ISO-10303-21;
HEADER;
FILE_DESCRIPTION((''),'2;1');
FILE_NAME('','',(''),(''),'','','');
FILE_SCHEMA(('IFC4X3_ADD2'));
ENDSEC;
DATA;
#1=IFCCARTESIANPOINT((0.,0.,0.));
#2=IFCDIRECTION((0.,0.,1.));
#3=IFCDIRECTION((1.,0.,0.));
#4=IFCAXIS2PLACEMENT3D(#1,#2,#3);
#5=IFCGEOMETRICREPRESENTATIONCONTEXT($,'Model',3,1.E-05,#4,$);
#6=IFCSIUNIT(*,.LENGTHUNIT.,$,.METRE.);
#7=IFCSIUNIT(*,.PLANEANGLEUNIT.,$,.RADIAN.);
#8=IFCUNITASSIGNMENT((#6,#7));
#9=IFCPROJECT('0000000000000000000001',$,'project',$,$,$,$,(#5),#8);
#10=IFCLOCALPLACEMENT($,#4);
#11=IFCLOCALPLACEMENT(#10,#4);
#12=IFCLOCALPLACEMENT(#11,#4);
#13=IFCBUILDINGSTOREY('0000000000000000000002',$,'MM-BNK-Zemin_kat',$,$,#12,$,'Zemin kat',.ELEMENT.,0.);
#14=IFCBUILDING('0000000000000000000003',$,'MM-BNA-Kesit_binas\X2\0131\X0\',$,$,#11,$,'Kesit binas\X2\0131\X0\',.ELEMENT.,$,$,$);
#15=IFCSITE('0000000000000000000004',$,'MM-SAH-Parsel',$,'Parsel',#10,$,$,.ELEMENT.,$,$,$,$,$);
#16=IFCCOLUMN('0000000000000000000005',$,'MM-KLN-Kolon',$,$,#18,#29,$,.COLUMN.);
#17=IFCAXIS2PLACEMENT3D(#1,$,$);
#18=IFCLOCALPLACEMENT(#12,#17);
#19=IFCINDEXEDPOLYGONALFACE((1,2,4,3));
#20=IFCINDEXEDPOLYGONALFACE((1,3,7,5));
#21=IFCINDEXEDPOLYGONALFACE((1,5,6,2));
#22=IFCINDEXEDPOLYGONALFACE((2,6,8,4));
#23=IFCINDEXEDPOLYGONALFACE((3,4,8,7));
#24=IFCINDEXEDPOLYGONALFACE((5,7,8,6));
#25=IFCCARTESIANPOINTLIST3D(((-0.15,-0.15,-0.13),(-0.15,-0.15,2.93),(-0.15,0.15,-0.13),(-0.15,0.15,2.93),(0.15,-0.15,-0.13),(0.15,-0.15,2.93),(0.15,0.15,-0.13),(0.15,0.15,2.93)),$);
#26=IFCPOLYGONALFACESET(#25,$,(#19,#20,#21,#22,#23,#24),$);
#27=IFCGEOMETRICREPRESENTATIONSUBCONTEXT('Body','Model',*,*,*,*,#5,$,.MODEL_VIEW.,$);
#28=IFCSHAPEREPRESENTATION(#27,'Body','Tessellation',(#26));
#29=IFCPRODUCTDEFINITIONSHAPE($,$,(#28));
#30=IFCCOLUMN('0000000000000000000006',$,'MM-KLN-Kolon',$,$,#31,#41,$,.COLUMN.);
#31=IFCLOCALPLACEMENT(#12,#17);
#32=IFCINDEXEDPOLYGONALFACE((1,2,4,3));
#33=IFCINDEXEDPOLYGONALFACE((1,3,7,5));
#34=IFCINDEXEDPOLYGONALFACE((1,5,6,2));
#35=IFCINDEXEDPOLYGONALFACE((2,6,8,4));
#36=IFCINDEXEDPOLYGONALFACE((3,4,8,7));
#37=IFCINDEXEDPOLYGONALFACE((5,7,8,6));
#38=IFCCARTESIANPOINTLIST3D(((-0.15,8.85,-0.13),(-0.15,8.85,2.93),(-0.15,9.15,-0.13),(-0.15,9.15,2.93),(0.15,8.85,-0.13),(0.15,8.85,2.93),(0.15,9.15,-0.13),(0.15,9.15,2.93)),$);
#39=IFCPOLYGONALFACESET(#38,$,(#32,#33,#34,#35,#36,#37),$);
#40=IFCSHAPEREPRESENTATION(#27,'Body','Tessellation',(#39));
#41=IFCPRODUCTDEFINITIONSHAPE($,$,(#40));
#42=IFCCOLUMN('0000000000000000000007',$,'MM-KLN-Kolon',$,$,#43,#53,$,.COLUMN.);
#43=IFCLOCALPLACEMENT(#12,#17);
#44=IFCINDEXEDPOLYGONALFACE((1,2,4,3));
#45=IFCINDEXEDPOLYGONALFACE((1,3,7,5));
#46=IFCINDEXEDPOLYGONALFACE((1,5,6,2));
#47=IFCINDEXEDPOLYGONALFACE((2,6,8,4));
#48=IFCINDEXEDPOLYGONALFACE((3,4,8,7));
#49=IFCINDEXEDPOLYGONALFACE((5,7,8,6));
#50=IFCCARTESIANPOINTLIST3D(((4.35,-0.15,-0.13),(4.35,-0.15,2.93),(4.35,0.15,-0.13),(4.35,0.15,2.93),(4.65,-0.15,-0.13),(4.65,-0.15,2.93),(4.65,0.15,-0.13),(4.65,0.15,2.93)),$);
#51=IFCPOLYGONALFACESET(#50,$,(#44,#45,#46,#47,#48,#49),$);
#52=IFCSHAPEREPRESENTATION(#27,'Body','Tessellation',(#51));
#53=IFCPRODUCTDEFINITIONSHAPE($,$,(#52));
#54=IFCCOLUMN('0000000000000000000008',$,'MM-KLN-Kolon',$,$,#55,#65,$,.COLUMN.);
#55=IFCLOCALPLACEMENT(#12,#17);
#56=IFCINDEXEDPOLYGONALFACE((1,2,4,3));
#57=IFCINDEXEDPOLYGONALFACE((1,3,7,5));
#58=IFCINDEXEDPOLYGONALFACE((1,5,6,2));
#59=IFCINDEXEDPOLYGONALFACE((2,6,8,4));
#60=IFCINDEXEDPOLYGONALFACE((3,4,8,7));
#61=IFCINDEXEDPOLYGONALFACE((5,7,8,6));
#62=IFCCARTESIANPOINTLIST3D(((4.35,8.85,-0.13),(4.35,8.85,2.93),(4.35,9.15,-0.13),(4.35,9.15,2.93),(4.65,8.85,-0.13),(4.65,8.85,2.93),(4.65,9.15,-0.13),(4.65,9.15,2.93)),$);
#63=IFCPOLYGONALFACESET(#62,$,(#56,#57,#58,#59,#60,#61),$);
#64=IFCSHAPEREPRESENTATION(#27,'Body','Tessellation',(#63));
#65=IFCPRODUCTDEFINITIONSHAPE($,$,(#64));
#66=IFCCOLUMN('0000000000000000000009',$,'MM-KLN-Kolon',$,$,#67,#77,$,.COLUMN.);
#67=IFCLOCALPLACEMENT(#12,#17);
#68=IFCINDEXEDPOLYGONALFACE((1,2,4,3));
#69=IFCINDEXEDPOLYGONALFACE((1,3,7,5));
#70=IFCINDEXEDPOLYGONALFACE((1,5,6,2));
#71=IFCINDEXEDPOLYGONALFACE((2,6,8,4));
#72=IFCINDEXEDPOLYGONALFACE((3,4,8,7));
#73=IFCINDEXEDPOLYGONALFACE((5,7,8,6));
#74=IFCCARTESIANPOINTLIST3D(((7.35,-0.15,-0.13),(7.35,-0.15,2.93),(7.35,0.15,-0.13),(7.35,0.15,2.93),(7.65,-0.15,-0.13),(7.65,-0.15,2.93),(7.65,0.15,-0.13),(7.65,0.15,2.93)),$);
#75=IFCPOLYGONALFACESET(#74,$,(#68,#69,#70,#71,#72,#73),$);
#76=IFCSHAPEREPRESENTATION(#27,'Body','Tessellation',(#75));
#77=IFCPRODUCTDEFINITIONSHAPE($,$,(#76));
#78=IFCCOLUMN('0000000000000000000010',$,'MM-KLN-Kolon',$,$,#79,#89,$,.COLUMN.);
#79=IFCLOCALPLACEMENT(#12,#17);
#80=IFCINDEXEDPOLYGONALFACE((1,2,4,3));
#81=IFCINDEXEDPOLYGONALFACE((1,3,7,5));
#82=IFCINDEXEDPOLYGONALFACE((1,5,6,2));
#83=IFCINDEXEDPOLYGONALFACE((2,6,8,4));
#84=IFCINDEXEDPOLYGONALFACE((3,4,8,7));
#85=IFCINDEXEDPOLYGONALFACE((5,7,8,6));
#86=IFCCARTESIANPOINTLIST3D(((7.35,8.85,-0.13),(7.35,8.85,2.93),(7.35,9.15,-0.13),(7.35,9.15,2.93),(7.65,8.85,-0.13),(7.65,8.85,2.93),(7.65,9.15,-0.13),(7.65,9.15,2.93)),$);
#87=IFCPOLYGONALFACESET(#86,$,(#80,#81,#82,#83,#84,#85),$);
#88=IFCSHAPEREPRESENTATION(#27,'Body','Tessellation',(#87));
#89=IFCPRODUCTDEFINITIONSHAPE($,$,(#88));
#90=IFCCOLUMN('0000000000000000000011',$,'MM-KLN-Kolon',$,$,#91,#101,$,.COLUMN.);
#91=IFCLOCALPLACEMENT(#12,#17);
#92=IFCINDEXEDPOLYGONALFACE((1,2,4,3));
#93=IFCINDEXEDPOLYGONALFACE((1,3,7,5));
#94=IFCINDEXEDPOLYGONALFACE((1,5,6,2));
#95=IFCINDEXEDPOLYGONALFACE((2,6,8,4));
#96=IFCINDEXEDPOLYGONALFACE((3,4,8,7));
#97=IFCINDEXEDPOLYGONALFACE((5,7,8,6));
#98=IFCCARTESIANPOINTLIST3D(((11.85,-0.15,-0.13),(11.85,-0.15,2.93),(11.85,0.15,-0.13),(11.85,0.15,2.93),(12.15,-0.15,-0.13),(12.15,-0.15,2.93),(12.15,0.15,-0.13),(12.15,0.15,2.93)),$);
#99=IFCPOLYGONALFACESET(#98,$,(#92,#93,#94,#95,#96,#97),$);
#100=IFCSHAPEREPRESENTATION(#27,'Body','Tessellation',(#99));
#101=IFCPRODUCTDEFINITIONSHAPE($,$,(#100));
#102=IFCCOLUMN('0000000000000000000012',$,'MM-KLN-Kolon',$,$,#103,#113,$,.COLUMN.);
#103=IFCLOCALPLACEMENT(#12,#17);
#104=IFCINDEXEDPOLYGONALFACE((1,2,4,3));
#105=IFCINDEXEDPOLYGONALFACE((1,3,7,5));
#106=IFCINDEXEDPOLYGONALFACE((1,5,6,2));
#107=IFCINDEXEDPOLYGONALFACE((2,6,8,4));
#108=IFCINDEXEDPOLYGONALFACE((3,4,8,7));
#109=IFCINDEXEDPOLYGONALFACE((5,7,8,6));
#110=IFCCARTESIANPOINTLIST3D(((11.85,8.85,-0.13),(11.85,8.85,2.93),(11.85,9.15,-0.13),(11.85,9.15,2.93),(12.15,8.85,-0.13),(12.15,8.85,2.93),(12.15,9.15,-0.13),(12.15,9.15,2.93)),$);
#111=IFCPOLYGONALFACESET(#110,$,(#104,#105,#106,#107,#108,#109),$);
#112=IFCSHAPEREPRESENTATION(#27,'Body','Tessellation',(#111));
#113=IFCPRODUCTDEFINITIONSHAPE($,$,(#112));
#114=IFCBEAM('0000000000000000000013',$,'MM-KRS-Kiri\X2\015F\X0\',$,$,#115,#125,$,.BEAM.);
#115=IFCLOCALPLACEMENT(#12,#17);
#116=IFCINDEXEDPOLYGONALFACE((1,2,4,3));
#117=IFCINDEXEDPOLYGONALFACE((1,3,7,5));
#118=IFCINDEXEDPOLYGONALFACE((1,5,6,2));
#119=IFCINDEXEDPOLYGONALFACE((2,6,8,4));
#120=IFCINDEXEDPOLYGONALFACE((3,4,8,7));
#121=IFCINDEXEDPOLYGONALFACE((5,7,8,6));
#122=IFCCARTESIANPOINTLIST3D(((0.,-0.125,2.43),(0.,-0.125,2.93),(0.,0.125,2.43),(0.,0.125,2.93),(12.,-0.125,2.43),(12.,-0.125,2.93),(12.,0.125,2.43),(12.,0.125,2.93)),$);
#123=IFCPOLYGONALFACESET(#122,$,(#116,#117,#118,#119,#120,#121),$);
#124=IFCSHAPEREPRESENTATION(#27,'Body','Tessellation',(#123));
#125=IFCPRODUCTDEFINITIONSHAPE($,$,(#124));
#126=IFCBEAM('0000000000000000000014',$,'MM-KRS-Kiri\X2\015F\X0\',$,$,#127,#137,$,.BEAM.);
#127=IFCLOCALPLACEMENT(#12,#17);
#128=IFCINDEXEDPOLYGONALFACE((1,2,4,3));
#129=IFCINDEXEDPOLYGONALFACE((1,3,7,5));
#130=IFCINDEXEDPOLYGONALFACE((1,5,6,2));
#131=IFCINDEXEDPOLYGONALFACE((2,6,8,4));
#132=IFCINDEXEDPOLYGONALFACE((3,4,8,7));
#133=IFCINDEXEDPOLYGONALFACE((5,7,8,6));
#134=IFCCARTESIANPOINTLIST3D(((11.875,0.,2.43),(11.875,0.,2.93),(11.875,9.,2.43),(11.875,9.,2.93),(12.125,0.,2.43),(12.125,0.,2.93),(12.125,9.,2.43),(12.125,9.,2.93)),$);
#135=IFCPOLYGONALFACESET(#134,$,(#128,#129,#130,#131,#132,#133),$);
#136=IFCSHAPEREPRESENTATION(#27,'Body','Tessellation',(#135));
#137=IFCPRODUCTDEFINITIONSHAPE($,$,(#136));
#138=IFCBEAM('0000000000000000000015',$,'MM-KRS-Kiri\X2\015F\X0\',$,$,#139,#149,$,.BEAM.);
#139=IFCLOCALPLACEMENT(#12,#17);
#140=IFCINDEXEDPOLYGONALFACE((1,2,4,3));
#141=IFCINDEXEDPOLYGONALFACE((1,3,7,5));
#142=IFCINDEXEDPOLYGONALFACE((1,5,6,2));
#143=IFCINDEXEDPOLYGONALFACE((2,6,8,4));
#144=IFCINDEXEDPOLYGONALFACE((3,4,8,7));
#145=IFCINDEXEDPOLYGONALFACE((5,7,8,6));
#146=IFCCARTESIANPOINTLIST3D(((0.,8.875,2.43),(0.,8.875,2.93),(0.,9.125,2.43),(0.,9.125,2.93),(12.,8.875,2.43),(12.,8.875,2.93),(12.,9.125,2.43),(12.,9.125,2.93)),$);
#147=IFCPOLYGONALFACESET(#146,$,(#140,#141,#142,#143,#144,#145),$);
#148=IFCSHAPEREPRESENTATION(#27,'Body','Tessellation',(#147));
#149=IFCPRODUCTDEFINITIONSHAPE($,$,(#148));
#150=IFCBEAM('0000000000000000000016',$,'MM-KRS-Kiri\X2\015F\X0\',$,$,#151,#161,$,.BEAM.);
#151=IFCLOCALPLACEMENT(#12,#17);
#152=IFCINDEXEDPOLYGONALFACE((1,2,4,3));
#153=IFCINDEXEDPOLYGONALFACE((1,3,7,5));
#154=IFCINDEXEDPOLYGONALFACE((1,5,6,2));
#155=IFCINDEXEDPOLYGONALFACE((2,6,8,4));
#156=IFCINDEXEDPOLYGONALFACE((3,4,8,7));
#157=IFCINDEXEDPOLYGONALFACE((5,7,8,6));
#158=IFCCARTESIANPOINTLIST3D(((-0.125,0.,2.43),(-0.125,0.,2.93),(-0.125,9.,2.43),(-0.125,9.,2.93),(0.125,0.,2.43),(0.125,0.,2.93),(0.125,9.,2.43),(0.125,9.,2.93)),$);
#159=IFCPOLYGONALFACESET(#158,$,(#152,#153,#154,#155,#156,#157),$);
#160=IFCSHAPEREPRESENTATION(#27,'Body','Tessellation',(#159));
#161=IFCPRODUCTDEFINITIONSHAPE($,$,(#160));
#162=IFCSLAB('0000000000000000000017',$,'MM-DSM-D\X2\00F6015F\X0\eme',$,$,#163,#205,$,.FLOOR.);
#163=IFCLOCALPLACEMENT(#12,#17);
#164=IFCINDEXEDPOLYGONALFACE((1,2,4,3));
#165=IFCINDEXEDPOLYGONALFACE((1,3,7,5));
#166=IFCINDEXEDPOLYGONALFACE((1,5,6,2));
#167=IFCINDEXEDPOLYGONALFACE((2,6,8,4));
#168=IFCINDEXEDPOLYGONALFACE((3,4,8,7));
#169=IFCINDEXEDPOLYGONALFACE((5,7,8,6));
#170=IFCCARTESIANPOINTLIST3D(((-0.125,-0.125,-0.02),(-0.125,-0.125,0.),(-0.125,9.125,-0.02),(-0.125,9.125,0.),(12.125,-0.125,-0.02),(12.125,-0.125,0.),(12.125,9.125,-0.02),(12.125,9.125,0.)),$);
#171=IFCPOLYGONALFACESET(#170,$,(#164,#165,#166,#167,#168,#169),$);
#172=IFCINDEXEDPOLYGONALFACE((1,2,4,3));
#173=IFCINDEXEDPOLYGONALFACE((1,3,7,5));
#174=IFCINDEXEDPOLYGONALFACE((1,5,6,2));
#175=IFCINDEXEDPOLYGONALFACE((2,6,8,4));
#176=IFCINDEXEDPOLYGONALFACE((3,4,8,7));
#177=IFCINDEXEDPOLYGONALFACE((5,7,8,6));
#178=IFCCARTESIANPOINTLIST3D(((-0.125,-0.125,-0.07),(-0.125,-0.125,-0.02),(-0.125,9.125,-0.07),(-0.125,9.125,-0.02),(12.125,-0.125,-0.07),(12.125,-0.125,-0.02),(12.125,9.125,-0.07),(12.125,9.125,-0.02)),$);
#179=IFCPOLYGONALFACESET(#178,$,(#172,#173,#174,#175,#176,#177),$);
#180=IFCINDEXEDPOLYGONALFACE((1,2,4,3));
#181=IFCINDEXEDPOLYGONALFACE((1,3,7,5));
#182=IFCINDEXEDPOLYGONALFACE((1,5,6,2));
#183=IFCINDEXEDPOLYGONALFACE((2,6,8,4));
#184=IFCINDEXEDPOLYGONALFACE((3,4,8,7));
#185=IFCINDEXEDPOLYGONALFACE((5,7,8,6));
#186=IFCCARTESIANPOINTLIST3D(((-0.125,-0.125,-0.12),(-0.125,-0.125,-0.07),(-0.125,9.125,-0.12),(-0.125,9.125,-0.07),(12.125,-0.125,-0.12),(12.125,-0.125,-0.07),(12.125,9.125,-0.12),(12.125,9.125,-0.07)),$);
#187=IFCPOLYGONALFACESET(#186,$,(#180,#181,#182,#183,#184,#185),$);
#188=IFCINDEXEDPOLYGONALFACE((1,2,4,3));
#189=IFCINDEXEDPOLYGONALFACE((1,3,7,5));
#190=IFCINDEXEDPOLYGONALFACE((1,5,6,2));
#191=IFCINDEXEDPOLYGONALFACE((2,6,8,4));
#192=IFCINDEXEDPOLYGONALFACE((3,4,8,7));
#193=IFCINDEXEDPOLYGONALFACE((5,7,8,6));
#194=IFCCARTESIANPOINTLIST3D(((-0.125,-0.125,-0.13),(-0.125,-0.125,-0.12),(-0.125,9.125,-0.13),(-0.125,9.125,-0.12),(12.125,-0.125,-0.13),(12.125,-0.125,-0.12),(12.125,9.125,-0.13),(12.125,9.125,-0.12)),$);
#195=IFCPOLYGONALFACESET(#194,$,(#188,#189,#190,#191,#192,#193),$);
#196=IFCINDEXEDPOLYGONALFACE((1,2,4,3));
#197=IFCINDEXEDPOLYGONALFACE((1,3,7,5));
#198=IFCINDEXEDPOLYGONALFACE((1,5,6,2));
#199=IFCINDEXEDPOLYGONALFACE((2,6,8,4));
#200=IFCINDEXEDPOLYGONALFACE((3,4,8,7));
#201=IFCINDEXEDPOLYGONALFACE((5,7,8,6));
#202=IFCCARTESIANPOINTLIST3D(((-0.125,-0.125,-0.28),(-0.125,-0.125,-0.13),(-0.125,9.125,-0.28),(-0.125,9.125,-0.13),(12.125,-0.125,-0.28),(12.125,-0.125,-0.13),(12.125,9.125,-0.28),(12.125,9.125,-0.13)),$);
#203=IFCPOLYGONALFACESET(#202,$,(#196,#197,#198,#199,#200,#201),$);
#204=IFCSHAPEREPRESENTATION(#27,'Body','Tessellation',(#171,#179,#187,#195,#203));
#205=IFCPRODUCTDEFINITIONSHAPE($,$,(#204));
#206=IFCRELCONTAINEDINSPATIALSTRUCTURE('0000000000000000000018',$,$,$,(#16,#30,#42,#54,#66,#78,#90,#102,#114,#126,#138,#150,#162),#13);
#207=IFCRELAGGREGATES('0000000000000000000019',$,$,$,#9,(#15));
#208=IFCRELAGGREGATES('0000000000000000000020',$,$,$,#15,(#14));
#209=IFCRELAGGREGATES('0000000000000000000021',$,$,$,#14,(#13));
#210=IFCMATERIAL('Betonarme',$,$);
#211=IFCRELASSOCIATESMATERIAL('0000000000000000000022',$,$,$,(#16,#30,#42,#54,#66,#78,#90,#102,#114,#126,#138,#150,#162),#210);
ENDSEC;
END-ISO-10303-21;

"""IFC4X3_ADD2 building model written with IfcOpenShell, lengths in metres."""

from ifc_helpers import new_model, si_unit, frame, origin_with_axes, place, context, subcontext, project, spatial, polyline, outline, extrude, material, element, save


model = new_model("IFC4X3_ADD2")

# Units and contexts
model_context = context("Model", 3, precision=1e-05, world=origin_with_axes())
body_context = subcontext(model_context, "Body", "Model", "MODEL_VIEW")
ifc_project = project(units=[si_unit("LENGTHUNIT", "METRE"), si_unit("PLANEANGLEUNIT", "RADIAN")], contexts=[model_context])

# Site, building, storey
site_placement = place(None, origin_with_axes())
site = spatial("IfcSite", under=ifc_project, at=site_placement, Name="MM-SAH-Parsel", ObjectType="Parsel", CompositionType="ELEMENT")
building_placement = place(site_placement, origin_with_axes())
building = spatial("IfcBuilding", under=site, at=building_placement, Name="MM-BNA-Kesit_binası", LongName="Kesit binası", CompositionType="ELEMENT")
storey_placement = place(building_placement, origin_with_axes())
storey = spatial("IfcBuildingStorey", under=building, at=storey_placement, Name="MM-BNK-Zemin_kat", LongName="Zemin kat", CompositionType="ELEMENT", Elevation=0.0)

# Columns
ifc_material_1 = material(Name="Betonarme")
column_1_placement = place(storey_placement, origin_with_axes())
element("IfcColumn", 1, at=column_1_placement, inside=storey, material=ifc_material_1, Name="MM-KLN-Kolon", PredefinedType="COLUMN", context=body_context, shape_type="SweptSolid", body=[
    extrude(outline(polyline([(-0.15, -0.15), (0.15, -0.15), (0.15, 0.15), (-0.15, 0.15), (-0.15, -0.15)])), frame((0.0, 0.0, -0.13)), (0.0, 0.0, 1.0), 3.06),
])
column_2_placement = place(storey_placement, origin_with_axes())
element("IfcColumn", 2, at=column_2_placement, inside=storey, material=ifc_material_1, Name="MM-KLN-Kolon", PredefinedType="COLUMN", context=body_context, shape_type="SweptSolid", body=[
    extrude(outline(polyline([(-0.15, 8.85), (0.15, 8.85), (0.15, 9.15), (-0.15, 9.15), (-0.15, 8.85)])), frame((0.0, 0.0, -0.13)), (0.0, 0.0, 1.0), 3.06),
])
column_3_placement = place(storey_placement, origin_with_axes())
element("IfcColumn", 3, at=column_3_placement, inside=storey, material=ifc_material_1, Name="MM-KLN-Kolon", PredefinedType="COLUMN", context=body_context, shape_type="SweptSolid", body=[
    extrude(outline(polyline([(4.35, -0.15), (4.65, -0.15), (4.65, 0.15), (4.35, 0.15), (4.35, -0.15)])), frame((0.0, 0.0, -0.13)), (0.0, 0.0, 1.0), 3.06),
])
column_4_placement = place(storey_placement, origin_with_axes())
element("IfcColumn", 4, at=column_4_placement, inside=storey, material=ifc_material_1, Name="MM-KLN-Kolon", PredefinedType="COLUMN", context=body_context, shape_type="SweptSolid", body=[
    extrude(outline(polyline([(4.35, 8.85), (4.65, 8.85), (4.65, 9.15), (4.35, 9.15), (4.35, 8.85)])), frame((0.0, 0.0, -0.13)), (0.0, 0.0, 1.0), 3.06),
])
column_5_placement = place(storey_placement, origin_with_axes())
element("IfcColumn", 5, at=column_5_placement, inside=storey, material=ifc_material_1, Name="MM-KLN-Kolon", PredefinedType="COLUMN", context=body_context, shape_type="SweptSolid", body=[
    extrude(outline(polyline([(7.35, -0.15), (7.65, -0.15), (7.65, 0.15), (7.35, 0.15), (7.35, -0.15)])), frame((0.0, 0.0, -0.13)), (0.0, 0.0, 1.0), 3.06),
])
column_6_placement = place(storey_placement, origin_with_axes())
element("IfcColumn", 6, at=column_6_placement, inside=storey, material=ifc_material_1, Name="MM-KLN-Kolon", PredefinedType="COLUMN", context=body_context, shape_type="SweptSolid", body=[
    extrude(outline(polyline([(7.35, 8.85), (7.65, 8.85), (7.65, 9.15), (7.35, 9.15), (7.35, 8.85)])), frame((0.0, 0.0, -0.13)), (0.0, 0.0, 1.0), 3.06),
])
column_7_placement = place(storey_placement, origin_with_axes())
element("IfcColumn", 7, at=column_7_placement, inside=storey, material=ifc_material_1, Name="MM-KLN-Kolon", PredefinedType="COLUMN", context=body_context, shape_type="SweptSolid", body=[
    extrude(outline(polyline([(11.85, -0.15), (12.15, -0.15), (12.15, 0.15), (11.85, 0.15), (11.85, -0.15)])), frame((0.0, 0.0, -0.13)), (0.0, 0.0, 1.0), 3.06),
])
column_8_placement = place(storey_placement, origin_with_axes())
element("IfcColumn", 8, at=column_8_placement, inside=storey, material=ifc_material_1, Name="MM-KLN-Kolon", PredefinedType="COLUMN", context=body_context, shape_type="SweptSolid", body=[
    extrude(outline(polyline([(11.85, 8.85), (12.15, 8.85), (12.15, 9.15), (11.85, 9.15), (11.85, 8.85)])), frame((0.0, 0.0, -0.13)), (0.0, 0.0, 1.0), 3.06),
])

# Beams
beam_1_placement = place(storey_placement, origin_with_axes())
element("IfcBeam", 9, at=beam_1_placement, inside=storey, material=ifc_material_1, Name="MM-KRS-Kiriş", PredefinedType="BEAM", context=body_context, shape_type="SweptSolid", body=[
    extrude(outline(polyline([(0.0, 0.125), (12.0, 0.125), (12.0, -0.125), (0.0, -0.125), (0.0, 0.125)])), frame((0.0, 0.0, 2.43)), (0.0, 0.0, 1.0), 0.5),
])
beam_2_placement = place(storey_placement, origin_with_axes())
element("IfcBeam", 10, at=beam_2_placement, inside=storey, material=ifc_material_1, Name="MM-KRS-Kiriş", PredefinedType="BEAM", context=body_context, shape_type="SweptSolid", body=[
    extrude(outline(polyline([(11.875, 0.0), (11.875, 9.0), (12.125, 9.0), (12.125, 0.0), (11.875, 0.0)])), frame((0.0, 0.0, 2.43)), (0.0, 0.0, 1.0), 0.5),
])
beam_3_placement = place(storey_placement, origin_with_axes())
element("IfcBeam", 11, at=beam_3_placement, inside=storey, material=ifc_material_1, Name="MM-KRS-Kiriş", PredefinedType="BEAM", context=body_context, shape_type="SweptSolid", body=[
    extrude(outline(polyline([(12.0, 8.875), (0.0, 8.875), (0.0, 9.125), (12.0, 9.125), (12.0, 8.875)])), frame((0.0, 0.0, 2.43)), (0.0, 0.0, 1.0), 0.5),
])
beam_4_placement = place(storey_placement, origin_with_axes())
element("IfcBeam", 12, at=beam_4_placement, inside=storey, material=ifc_material_1, Name="MM-KRS-Kiriş", PredefinedType="BEAM", context=body_context, shape_type="SweptSolid", body=[
    extrude(outline(polyline([(0.125, 9.0), (0.125, 0.0), (-0.125, 0.0), (-0.125, 9.0), (0.125, 9.0)])), frame((0.0, 0.0, 2.43)), (0.0, 0.0, 1.0), 0.5),
])

# Slab
slab_placement = place(storey_placement, origin_with_axes())
element("IfcSlab", 13, at=slab_placement, inside=storey, material=ifc_material_1, Name="MM-DSM-Döşeme", PredefinedType="FLOOR", context=body_context, shape_type="SweptSolid", body=[
    extrude(outline(polyline([(-0.125, -0.125), (12.125, -0.125), (12.125, 9.125), (-0.125, 9.125), (-0.125, -0.125)])), frame((0.0, 0.0, -0.02)), (0.0, 0.0, 1.0), 0.02),
    extrude(outline(polyline([(-0.125, -0.125), (12.125, -0.125), (12.125, 9.125), (-0.125, 9.125), (-0.125, -0.125)])), frame((0.0, 0.0, -0.07)), (0.0, 0.0, 1.0), 0.05),
    extrude(outline(polyline([(-0.125, -0.125), (12.125, -0.125), (12.125, 9.125), (-0.125, 9.125), (-0.125, -0.125)])), frame((0.0, 0.0, -0.12)), (0.0, 0.0, 1.0), 0.05),
    extrude(outline(polyline([(-0.125, -0.125), (12.125, -0.125), (12.125, 9.125), (-0.125, 9.125), (-0.125, -0.125)])), frame((0.0, 0.0, -0.13)), (0.0, 0.0, 1.0), 0.01),
    extrude(outline(polyline([(-0.125, -0.125), (12.125, -0.125), (12.125, 9.125), (-0.125, 9.125), (-0.125, -0.125)])), frame((0.0, 0.0, -0.28)), (0.0, 0.0, 1.0), 0.15),
])

save(model, "model.ifc")
